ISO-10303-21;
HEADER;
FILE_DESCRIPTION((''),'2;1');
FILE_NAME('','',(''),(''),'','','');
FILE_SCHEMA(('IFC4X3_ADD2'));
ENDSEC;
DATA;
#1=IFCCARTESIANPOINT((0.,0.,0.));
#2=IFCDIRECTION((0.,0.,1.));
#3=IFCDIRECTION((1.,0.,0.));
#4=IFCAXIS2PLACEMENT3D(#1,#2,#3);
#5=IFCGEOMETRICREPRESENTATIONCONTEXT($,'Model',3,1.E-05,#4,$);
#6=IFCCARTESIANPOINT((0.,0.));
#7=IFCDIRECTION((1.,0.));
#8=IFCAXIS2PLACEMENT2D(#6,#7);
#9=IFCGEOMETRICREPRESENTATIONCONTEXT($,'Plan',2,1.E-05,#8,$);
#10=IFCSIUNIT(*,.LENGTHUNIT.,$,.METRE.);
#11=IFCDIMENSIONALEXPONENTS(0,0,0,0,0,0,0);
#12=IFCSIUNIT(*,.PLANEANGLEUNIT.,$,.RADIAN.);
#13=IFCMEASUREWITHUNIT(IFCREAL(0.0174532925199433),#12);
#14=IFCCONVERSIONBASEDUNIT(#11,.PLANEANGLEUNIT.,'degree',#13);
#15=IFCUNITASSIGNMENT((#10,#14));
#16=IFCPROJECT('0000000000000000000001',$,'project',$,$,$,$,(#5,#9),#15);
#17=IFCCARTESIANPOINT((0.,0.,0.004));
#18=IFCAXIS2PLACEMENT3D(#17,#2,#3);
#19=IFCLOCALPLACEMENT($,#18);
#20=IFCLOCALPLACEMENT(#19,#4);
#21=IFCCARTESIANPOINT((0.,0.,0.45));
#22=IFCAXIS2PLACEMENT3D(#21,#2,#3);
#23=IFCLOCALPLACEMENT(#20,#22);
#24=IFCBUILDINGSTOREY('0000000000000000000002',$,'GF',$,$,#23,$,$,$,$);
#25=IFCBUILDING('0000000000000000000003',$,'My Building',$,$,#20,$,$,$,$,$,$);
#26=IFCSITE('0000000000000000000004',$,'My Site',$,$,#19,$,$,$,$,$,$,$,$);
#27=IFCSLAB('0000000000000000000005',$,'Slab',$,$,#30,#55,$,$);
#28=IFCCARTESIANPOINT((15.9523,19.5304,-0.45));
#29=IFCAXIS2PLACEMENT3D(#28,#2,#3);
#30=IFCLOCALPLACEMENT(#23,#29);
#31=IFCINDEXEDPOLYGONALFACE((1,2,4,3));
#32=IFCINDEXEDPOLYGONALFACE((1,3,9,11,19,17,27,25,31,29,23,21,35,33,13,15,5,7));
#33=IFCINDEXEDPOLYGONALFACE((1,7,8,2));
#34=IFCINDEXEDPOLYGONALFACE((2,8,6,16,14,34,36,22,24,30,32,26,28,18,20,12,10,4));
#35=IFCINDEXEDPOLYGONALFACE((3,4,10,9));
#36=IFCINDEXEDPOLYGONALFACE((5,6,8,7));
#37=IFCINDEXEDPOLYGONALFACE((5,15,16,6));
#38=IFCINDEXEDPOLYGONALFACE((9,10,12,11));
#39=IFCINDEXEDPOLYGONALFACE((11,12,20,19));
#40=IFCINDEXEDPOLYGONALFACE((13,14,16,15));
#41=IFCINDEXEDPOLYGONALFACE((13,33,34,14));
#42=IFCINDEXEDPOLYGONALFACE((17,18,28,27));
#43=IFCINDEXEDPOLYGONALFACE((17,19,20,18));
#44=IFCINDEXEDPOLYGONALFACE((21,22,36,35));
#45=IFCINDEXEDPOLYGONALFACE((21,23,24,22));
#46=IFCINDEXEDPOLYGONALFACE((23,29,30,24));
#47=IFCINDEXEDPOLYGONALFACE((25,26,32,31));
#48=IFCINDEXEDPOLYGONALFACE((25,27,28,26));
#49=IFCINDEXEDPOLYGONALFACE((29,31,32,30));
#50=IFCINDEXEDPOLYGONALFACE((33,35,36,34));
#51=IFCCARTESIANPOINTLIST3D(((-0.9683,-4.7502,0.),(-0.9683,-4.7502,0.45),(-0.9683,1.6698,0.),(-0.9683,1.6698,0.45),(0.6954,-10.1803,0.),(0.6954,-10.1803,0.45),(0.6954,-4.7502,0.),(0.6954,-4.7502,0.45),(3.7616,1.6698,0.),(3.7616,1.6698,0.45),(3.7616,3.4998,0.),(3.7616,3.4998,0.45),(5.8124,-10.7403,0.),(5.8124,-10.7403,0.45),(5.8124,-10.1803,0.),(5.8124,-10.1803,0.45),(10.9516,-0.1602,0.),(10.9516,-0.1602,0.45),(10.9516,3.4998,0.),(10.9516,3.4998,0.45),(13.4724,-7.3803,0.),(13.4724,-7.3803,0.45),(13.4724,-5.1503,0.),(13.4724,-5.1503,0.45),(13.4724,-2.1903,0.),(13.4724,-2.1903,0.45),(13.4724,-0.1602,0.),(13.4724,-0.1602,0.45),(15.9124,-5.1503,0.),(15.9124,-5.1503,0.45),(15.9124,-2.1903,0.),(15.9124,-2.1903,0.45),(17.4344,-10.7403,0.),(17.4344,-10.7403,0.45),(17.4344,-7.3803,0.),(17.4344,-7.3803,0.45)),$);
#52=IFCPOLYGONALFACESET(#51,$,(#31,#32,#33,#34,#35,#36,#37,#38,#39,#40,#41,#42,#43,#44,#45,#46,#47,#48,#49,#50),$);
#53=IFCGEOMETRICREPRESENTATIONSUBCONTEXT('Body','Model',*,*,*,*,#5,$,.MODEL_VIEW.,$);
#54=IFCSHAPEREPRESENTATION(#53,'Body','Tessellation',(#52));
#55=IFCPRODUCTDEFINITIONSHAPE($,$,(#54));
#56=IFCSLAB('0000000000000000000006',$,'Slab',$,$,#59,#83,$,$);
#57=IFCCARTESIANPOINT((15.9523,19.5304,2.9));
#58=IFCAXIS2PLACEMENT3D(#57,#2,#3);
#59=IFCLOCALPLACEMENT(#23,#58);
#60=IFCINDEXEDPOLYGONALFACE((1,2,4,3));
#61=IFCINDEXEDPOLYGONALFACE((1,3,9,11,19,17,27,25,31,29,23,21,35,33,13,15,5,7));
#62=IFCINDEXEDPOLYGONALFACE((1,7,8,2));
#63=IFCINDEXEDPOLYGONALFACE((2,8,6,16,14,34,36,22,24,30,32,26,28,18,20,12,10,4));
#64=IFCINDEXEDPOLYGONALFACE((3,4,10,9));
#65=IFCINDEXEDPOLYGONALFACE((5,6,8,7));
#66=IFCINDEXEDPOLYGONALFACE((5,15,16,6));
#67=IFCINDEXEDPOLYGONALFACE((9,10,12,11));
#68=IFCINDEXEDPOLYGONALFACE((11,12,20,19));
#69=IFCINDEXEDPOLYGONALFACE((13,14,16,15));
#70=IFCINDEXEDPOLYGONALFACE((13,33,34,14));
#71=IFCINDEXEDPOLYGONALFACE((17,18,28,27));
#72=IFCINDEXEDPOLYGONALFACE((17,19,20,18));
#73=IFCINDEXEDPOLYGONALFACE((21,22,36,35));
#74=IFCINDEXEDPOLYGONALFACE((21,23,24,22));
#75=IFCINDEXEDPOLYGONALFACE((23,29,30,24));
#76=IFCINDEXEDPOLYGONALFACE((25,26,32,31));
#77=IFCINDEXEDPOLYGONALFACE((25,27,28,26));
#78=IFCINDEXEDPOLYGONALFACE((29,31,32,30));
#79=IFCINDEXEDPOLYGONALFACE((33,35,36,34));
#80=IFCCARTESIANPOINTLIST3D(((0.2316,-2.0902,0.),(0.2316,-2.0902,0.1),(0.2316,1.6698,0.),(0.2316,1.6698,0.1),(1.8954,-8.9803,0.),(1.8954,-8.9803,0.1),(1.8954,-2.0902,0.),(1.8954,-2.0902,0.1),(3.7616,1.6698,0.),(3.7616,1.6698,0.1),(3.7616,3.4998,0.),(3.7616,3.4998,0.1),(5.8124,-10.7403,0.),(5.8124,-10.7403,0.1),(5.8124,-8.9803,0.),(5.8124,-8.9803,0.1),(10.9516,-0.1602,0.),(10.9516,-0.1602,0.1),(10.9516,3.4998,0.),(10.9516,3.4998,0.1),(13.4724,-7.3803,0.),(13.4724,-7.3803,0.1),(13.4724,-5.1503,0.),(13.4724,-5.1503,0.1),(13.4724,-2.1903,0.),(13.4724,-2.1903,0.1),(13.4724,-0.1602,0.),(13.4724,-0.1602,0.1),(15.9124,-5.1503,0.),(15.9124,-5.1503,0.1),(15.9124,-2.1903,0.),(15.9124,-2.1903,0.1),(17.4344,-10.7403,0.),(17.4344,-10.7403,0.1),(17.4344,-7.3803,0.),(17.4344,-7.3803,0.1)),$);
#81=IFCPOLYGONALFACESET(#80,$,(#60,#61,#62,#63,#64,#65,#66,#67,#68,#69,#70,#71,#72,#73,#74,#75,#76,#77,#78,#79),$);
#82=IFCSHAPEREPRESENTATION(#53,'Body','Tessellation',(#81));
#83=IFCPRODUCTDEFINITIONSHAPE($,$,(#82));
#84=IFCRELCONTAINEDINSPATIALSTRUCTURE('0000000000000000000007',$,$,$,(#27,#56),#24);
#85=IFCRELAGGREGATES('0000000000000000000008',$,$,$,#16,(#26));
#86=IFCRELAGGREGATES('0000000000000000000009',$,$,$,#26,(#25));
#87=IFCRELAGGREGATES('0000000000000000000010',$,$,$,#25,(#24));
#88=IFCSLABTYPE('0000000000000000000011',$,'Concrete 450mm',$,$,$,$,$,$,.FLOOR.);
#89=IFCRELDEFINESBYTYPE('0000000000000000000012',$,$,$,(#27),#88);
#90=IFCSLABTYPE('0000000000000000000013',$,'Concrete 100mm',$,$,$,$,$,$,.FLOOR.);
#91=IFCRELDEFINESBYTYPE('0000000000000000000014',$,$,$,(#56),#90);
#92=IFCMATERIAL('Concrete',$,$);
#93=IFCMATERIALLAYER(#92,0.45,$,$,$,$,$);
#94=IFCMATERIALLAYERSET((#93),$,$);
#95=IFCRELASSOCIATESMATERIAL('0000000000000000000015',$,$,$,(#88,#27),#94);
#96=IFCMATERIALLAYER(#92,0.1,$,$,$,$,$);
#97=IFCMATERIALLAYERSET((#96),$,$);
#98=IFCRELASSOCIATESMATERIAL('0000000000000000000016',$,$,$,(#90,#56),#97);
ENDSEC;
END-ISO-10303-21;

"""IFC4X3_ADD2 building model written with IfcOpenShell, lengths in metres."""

from ifc_helpers import new_model, entity, si_unit, converted_unit, frame, origin_with_axes, origin_2d_with_axis, place, context, subcontext, project, spatial, line, indexed_curve, outline, extrude, material, layer, layer_set, layer_usage, type_object, element, save


model = new_model("IFC4X3_ADD2")

# Units and contexts
model_context = context("Model", 3, precision=1e-05, world=origin_with_axes())
plan_context = context("Plan", 2, precision=1e-05, world=origin_2d_with_axis())
body_context_1 = subcontext(model_context, "Body", "Model", "MODEL_VIEW")
ifc_project = project(units=[si_unit("LENGTHUNIT", "METRE"), converted_unit("PLANEANGLEUNIT", "degree", entity("IfcReal", 0.0174532925199433), si_unit("PLANEANGLEUNIT", "RADIAN"), dimensions=[0, 0, 0, 0, 0, 0, 0])], contexts=[model_context, plan_context])

# Site, building, storey
site_placement = place(None, frame((0.0, 0.0, 0.004), z_axis=(0.0, 0.0, 1.0), x_axis=(1.0, 0.0, 0.0)))
site = spatial("IfcSite", under=ifc_project, at=site_placement, Name="My Site")
building_placement = place(site_placement, origin_with_axes())
building = spatial("IfcBuilding", under=site, at=building_placement, Name="My Building")
storey_placement = place(building_placement, frame((0.0, 0.0, 0.45), z_axis=(0.0, 0.0, 1.0), x_axis=(1.0, 0.0, 0.0)))
storey = spatial("IfcBuildingStorey", under=building, at=storey_placement, Name="GF")

# Slabs
ifc_material_1 = material(Name="Concrete")
ifc_layer_1 = layer(ifc_material_1, 0.45)
ifc_layer_set_1 = layer_set([ifc_layer_1])
ifc_layer_usage_1 = layer_usage(ifc_layer_set_1, "AXIS3", "POSITIVE", 0.0)
slab_type_1 = type_object("IfcSlabType", Name="Concrete 450mm", PredefinedType="FLOOR", material=ifc_layer_set_1)
slab_1_placement = place(storey_placement, frame((15.9523, 19.5304, -0.45), z_axis=(0.0, 0.0, 1.0), x_axis=(1.0, 0.0, 0.0)))
element("IfcSlab", 1, at=slab_1_placement, inside=storey, type_object=slab_type_1, material=ifc_layer_usage_1, Name="Slab", context=body_context_1, shape_type="SweptSolid", body=[
    extrude(outline(indexed_curve([(13.4724, -5.1503), (15.9124, -5.1503), (15.9124, -2.1903), (13.4724, -2.1903), (13.4724, -0.1602), (10.9516, -0.1602), (10.9516, 3.4998), (3.7616, 3.4998), (3.7616, 1.6698), (-0.9683, 1.6698), (-0.9683, -4.7502), (0.6954, -4.7502), (0.6954, -10.1803), (5.8124, -10.1803), (5.8124, -10.7403), (17.4344, -10.7403), (17.4344, -7.3803), (13.4724, -7.3803)], segments=[line(3, 4), line(4, 5), line(5, 6), line(6, 7), line(7, 8), line(8, 9), line(9, 10), line(10, 11), line(11, 12), line(12, 13), line(13, 14), line(14, 15), line(15, 16), line(16, 17), line(17, 18), line(18, 1), line(1, 2), line(2, 3)], self_intersect=False)), None, (0.0, 0.0, 1.0), 0.45),
])
ifc_layer_2 = layer(ifc_material_1, 0.1)
ifc_layer_set_2 = layer_set([ifc_layer_2])
ifc_layer_usage_2 = layer_usage(ifc_layer_set_2, "AXIS3", "POSITIVE", 0.0)
slab_type_2 = type_object("IfcSlabType", Name="Concrete 100mm", PredefinedType="FLOOR", material=ifc_layer_set_2)
slab_2_placement = place(storey_placement, frame((15.9523, 19.5304, 2.9), z_axis=(0.0, 0.0, 1.0), x_axis=(1.0, 0.0, 0.0)))
element("IfcSlab", 2, at=slab_2_placement, inside=storey, type_object=slab_type_2, material=ifc_layer_usage_2, Name="Slab", context=body_context_1, shape_type="SweptSolid", body=[
    extrude(outline(indexed_curve([(10.9516, 3.4998), (10.9516, -0.1602), (13.4724, -0.1602), (13.4724, -2.1903), (15.9124, -2.1903), (15.9124, -5.1503), (13.4724, -5.1503), (13.4724, -7.3803), (17.4344, -7.3803), (17.4344, -10.7403), (5.8124, -10.7403), (5.8124, -8.9803), (1.8954, -8.9803), (1.8954, -2.0902), (0.2316, -2.0902), (0.2316, 1.6698), (3.7616, 1.6698), (3.7616, 3.4998)], segments=[line(12, 11), line(11, 10), line(10, 9), line(9, 8), line(8, 7), line(7, 6), line(6, 5), line(5, 4), line(4, 3), line(3, 2), line(2, 1), line(1, 18), line(18, 17), line(17, 16), line(16, 15), line(15, 14), line(14, 13), line(13, 12)], self_intersect=False)), None, (0.0, 0.0, 1.0), 0.1),
])

save(model, "model.ifc")
